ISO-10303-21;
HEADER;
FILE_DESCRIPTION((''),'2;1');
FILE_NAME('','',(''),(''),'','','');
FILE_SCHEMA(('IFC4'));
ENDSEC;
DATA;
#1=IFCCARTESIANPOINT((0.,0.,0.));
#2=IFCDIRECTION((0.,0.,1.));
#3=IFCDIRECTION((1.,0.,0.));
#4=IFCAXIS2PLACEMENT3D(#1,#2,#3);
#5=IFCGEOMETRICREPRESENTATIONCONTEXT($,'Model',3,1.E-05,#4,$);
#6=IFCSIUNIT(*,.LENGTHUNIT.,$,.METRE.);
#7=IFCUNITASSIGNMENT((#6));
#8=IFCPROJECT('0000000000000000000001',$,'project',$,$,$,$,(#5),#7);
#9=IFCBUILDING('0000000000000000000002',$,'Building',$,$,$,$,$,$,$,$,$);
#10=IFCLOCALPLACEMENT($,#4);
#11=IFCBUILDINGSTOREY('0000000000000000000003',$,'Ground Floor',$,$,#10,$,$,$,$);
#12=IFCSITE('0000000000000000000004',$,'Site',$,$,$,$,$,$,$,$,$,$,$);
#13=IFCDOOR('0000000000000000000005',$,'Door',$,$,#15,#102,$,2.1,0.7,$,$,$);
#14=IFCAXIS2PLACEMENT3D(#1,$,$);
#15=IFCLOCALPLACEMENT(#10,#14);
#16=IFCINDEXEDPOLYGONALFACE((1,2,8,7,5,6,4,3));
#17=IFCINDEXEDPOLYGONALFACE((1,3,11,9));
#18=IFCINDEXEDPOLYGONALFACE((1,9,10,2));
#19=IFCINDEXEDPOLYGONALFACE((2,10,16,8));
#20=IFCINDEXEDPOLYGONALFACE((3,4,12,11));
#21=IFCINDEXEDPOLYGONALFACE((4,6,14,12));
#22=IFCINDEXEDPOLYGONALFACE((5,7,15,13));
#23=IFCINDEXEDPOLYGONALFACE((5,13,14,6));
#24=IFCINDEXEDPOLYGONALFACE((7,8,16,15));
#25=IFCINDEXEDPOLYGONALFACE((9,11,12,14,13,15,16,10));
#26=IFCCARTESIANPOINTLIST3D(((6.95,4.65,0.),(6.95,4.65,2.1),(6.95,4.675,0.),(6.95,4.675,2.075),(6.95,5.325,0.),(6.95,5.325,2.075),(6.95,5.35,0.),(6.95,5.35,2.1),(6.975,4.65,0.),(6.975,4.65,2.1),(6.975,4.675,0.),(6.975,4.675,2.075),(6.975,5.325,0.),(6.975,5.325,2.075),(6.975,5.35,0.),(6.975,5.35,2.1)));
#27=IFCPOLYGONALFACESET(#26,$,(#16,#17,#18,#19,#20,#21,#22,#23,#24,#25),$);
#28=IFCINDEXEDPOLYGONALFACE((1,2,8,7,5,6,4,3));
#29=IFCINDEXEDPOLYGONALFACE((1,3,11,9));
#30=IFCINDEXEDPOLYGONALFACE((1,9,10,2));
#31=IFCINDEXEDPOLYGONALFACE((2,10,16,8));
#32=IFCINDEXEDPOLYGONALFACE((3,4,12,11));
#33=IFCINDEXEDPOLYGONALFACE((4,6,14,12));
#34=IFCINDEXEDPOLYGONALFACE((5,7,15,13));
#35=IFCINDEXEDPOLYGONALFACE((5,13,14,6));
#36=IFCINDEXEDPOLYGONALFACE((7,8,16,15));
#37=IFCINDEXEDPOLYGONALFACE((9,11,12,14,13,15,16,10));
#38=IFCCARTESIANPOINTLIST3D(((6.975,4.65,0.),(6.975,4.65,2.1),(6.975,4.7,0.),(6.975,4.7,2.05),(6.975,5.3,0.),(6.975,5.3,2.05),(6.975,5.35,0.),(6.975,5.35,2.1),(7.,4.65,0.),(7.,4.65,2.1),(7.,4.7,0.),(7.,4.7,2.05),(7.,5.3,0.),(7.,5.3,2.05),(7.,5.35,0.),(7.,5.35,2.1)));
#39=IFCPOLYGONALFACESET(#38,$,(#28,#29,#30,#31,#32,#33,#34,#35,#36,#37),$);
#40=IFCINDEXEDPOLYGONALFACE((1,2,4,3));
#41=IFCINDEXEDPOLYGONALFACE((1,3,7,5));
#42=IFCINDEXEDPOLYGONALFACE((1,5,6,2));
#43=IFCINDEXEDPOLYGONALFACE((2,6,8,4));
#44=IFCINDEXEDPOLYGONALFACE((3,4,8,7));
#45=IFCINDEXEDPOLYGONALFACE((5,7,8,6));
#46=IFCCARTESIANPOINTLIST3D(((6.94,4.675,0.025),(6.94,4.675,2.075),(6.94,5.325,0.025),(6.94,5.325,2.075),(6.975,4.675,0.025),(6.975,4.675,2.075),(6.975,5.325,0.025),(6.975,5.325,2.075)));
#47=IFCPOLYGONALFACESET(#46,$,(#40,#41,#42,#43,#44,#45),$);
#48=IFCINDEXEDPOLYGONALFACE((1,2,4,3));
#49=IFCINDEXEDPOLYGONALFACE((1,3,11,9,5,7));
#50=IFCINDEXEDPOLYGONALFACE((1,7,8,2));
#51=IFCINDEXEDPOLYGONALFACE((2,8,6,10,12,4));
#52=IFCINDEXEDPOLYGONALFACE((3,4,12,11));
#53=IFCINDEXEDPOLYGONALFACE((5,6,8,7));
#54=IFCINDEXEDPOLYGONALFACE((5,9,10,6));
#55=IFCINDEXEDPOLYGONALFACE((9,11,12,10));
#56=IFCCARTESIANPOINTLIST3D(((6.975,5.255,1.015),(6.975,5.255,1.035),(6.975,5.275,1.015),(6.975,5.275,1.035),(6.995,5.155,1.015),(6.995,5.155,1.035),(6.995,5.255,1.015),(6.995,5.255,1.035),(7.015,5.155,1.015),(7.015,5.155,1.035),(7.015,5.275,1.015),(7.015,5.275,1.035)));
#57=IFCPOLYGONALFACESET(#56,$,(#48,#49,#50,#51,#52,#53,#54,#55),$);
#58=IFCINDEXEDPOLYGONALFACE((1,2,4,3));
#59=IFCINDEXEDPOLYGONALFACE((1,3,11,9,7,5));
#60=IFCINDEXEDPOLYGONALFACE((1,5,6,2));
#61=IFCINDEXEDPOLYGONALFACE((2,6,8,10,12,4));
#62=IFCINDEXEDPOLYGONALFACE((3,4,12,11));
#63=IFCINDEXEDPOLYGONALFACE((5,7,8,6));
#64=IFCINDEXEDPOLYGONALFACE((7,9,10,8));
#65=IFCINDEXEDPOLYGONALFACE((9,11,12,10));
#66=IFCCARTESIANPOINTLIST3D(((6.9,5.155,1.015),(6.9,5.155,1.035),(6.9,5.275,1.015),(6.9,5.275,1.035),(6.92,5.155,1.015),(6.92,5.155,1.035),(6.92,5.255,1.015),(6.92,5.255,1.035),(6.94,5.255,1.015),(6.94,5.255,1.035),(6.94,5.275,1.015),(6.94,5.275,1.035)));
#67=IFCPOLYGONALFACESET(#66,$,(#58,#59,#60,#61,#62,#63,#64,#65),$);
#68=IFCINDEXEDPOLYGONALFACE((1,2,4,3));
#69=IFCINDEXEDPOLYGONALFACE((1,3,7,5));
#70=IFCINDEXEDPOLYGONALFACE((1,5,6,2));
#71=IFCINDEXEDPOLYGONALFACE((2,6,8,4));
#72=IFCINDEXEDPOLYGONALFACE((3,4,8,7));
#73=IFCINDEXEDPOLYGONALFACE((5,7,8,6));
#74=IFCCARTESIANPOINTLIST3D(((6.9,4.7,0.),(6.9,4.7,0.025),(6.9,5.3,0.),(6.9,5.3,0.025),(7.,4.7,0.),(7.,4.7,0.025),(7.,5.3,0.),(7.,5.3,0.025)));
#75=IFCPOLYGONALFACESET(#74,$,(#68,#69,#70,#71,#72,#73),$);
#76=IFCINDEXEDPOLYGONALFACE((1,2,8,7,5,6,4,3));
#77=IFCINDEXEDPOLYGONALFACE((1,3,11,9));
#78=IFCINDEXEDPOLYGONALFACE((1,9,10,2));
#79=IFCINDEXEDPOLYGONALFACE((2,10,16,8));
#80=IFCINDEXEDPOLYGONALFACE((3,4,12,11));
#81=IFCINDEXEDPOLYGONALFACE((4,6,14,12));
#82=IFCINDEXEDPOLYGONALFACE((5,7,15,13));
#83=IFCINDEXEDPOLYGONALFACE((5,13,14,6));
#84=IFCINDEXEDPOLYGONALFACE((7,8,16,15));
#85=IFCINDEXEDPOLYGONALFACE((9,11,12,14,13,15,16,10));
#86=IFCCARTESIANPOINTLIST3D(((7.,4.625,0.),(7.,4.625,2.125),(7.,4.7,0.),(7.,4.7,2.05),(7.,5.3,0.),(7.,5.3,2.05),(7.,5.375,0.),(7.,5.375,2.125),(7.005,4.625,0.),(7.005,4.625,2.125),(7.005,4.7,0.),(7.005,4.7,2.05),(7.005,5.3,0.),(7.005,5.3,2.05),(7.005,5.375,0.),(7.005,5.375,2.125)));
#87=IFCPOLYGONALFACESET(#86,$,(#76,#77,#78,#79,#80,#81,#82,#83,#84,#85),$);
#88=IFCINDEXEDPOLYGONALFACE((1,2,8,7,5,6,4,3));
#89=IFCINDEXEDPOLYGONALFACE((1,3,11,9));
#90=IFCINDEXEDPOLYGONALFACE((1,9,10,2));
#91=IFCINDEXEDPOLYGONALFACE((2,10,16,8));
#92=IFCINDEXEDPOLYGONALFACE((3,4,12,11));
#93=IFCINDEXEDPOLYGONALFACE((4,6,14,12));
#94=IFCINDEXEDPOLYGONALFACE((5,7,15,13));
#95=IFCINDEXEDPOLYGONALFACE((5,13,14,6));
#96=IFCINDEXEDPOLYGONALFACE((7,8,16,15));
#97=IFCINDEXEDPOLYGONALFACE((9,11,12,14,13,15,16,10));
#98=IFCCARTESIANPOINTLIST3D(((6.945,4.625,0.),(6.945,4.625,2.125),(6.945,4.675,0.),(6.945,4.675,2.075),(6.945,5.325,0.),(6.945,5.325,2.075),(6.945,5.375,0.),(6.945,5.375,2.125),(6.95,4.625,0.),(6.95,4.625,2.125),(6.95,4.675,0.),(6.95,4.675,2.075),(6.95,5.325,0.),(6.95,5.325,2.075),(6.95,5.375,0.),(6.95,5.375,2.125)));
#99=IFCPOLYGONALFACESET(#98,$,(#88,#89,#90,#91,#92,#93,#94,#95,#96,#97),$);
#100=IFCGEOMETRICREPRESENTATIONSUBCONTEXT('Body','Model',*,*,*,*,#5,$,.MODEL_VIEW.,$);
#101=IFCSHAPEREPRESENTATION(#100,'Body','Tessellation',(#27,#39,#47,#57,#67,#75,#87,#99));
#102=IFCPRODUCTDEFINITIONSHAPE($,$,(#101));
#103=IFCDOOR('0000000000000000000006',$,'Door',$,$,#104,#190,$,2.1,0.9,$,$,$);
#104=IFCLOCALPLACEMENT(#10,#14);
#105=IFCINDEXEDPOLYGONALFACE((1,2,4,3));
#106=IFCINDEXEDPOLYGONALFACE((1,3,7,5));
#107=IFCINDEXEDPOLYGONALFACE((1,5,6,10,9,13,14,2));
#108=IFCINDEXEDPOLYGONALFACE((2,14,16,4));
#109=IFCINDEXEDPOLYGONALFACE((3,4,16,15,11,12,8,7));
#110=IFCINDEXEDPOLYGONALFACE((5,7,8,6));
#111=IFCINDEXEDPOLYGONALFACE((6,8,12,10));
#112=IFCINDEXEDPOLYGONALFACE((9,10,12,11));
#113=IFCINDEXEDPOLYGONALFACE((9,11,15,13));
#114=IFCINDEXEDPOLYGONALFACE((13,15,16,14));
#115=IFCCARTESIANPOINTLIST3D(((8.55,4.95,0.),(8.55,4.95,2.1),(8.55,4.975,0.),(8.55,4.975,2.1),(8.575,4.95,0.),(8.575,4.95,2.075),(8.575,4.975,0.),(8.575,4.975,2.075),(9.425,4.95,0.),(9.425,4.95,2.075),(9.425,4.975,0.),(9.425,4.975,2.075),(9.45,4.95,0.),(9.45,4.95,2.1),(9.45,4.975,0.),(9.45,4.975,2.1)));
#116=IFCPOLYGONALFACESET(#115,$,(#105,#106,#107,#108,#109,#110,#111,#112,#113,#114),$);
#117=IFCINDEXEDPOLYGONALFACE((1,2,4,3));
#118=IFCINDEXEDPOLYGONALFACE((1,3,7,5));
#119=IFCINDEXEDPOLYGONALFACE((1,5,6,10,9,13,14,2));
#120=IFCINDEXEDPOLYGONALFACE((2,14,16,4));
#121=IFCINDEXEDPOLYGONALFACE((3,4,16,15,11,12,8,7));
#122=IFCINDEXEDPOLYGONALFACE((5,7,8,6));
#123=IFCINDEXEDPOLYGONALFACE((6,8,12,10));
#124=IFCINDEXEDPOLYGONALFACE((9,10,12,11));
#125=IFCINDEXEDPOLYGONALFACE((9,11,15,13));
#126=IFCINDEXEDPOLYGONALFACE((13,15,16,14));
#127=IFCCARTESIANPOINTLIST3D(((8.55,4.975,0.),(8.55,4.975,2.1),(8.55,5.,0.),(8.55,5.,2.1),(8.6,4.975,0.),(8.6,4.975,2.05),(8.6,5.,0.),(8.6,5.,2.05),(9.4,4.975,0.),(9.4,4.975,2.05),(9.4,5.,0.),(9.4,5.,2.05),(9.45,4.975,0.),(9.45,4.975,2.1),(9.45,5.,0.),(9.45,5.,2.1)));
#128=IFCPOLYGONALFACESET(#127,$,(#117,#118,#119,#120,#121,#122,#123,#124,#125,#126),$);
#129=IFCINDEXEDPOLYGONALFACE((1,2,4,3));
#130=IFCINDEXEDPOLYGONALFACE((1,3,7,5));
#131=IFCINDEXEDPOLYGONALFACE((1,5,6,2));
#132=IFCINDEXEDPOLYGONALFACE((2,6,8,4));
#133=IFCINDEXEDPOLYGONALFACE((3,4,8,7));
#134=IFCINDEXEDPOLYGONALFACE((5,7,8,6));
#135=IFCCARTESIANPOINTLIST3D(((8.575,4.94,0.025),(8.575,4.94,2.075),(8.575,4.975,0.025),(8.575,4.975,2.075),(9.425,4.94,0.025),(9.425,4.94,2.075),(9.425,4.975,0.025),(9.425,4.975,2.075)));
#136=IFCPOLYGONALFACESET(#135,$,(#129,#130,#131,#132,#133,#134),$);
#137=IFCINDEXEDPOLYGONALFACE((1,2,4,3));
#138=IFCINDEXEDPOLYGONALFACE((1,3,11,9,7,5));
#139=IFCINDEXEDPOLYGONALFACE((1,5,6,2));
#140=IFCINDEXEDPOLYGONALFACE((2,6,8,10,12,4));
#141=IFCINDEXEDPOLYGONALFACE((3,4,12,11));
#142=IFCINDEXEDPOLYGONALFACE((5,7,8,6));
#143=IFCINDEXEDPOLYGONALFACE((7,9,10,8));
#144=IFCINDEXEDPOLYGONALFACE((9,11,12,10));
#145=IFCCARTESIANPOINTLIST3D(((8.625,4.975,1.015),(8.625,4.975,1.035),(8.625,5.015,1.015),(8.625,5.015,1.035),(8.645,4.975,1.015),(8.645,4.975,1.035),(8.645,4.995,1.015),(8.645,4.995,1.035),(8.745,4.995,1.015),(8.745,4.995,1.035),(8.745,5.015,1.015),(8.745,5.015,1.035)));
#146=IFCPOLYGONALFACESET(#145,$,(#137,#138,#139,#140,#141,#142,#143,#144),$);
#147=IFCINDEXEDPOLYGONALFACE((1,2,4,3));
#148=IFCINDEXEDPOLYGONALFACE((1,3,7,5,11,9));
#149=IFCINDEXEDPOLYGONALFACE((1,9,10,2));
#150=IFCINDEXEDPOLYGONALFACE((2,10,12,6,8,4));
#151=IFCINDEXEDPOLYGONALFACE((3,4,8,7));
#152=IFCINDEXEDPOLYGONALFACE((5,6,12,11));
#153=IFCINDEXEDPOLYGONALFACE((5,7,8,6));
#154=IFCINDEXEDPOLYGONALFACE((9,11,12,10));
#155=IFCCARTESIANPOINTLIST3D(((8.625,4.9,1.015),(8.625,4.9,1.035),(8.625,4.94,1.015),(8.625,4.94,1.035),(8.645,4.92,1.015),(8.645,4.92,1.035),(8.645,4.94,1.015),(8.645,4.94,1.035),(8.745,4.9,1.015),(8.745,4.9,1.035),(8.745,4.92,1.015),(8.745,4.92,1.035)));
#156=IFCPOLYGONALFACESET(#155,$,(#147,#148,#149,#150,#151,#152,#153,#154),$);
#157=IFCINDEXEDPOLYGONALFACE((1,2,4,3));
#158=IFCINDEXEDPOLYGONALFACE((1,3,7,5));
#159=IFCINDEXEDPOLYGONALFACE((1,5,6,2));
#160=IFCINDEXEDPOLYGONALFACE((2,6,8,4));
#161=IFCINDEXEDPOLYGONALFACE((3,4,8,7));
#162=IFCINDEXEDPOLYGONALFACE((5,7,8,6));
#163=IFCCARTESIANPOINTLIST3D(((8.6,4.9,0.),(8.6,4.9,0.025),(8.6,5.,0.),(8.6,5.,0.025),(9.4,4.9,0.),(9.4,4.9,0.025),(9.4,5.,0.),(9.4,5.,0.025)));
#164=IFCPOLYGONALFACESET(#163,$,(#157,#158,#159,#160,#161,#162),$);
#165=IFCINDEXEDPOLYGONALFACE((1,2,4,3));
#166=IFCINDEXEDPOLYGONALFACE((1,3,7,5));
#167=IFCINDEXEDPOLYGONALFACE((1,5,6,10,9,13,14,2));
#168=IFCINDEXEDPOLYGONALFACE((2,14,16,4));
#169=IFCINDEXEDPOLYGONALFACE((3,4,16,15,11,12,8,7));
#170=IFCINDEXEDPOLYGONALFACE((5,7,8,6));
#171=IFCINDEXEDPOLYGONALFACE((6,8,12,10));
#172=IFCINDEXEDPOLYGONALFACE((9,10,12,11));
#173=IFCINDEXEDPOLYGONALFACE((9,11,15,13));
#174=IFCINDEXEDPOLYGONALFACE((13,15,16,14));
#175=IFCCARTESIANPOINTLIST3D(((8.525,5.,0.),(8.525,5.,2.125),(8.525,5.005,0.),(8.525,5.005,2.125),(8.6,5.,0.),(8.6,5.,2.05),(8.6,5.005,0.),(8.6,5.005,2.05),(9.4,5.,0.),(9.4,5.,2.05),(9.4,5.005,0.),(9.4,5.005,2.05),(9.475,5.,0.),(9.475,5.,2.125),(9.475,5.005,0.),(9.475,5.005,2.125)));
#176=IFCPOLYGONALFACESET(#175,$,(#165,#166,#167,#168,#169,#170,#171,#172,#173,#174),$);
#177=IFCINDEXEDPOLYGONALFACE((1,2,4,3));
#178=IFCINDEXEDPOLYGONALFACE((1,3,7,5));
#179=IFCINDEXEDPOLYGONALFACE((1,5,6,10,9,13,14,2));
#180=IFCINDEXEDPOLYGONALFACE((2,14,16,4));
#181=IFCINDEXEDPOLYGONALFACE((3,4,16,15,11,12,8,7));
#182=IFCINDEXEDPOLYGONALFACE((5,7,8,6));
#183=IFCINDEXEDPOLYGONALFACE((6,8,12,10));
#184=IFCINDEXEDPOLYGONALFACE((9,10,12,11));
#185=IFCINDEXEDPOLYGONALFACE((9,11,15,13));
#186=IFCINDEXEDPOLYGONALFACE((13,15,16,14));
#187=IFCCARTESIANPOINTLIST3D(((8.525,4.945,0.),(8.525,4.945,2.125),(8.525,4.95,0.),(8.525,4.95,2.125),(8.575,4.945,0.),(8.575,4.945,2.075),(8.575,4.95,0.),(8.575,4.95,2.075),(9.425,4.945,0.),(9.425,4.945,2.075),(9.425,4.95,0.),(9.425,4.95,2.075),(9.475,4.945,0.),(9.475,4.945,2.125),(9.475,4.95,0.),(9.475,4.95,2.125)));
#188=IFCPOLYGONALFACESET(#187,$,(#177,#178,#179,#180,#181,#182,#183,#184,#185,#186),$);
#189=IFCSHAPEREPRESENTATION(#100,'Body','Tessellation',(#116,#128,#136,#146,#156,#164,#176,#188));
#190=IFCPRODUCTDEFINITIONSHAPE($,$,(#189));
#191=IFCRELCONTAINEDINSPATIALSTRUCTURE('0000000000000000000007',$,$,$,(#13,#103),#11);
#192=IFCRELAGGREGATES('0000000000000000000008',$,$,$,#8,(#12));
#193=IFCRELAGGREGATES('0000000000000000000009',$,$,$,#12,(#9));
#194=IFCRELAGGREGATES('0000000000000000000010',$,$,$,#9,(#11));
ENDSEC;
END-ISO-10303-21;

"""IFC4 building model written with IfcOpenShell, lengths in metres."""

from ifc_helpers import new_model, si_unit, frame, origin_with_axes, place, context, subcontext, project, spatial, line, indexed_curve, outline, extrude, element, save


model = new_model("IFC4")

# Units and contexts
model_context = context("Model", 3, precision=1e-05, world=origin_with_axes())
body_context = subcontext(model_context, "Body", "Model", "MODEL_VIEW")
ifc_project = project(units=[si_unit("LENGTHUNIT", "METRE")], contexts=[model_context])

# Site, building, storey
site = spatial("IfcSite", under=ifc_project, Name="Site")
building = spatial("IfcBuilding", under=site, Name="Building")
storey_placement = place(None, origin_with_axes())
storey = spatial("IfcBuildingStorey", under=building, at=storey_placement, Name="Ground Floor")

# Doors
door_1_placement = place(storey_placement, frame((7.0, 4.65, 0.0), z_axis=(0.0, 0.0, 1.0), x_axis=(0.0, 1.0, 0.0)))
element("IfcDoor", 1, at=door_1_placement, inside=storey, Name="Door", OverallHeight=2.1, OverallWidth=0.7, context=body_context, shape_type="SweptSolid", body=[
    extrude(outline(indexed_curve([(0.0, 0.0), (0.0, 2.1), (0.7, 2.1), (0.7, 0.0), (0.675, 0.0), (0.675, 2.075), (0.025, 2.075), (0.025, 0.0)], segments=[line(1, 2, 3, 4, 5, 6, 7, 8, 1)])), frame((0.0, 0.025, 0.0), z_axis=(0.0, -1.0, 0.0), x_axis=(1.0, 0.0, 0.0)), (0.0, 0.0, -1.0), 0.025),
    extrude(outline(indexed_curve([(0.0, 0.0), (0.0, 2.1), (0.7, 2.1), (0.7, 0.0), (0.65, 0.0), (0.65, 2.05), (0.05, 2.05), (0.05, 0.0)], segments=[line(1, 2, 3, 4, 5, 6, 7, 8, 1)])), frame((0.0, 0.0, 0.0), z_axis=(0.0, -1.0, 0.0), x_axis=(1.0, 0.0, 0.0)), (0.0, 0.0, -1.0), 0.025),
    extrude(outline(indexed_curve([(0.0, 0.0), (0.65, 0.0), (0.65, 0.035), (0.0, 0.035)], segments=[line(1, 2, 3, 4, 1)])), frame((0.025, 0.025, 0.025), z_axis=(0.0, 0.0, 1.0), x_axis=(1.0, 0.0, 0.0)), (0.0, 0.0, 1.0), 2.05),
    extrude(outline(indexed_curve([(0.0, 0.0), (0.0, -0.04), (-0.12, -0.04), (-0.12, -0.02), (-0.02, -0.02), (-0.02, 0.0)], segments=[line(1, 2, 3, 4, 5, 6, 1)])), frame((0.625, 0.025, 1.015), z_axis=(0.0, 0.0, 1.0), x_axis=(1.0, 0.0, 0.0)), (0.0, 0.0, 1.0), 0.02),
    extrude(outline(indexed_curve([(0.0, 0.0), (0.0, 0.04), (-0.12, 0.04), (-0.12, 0.02), (-0.02, 0.02), (-0.02, 0.0)], segments=[line(1, 2, 3, 4, 5, 6, 1)])), frame((0.625, 0.06, 1.015), z_axis=(0.0, 0.0, 1.0), x_axis=(1.0, 0.0, 0.0)), (0.0, 0.0, 1.0), 0.02),
    extrude(outline(indexed_curve([(0.0, 0.0), (0.6, 0.0), (0.6, 0.1), (0.0, 0.1)], segments=[line(1, 2, 3, 4, 1)])), frame((0.05, 0.0, 0.0), z_axis=(0.0, 0.0, 1.0), x_axis=(1.0, 0.0, 0.0)), (0.0, 0.0, 1.0), 0.025),
    extrude(outline(indexed_curve([(0.0, 0.0), (0.0, 2.125), (0.75, 2.125), (0.75, 0.0), (0.675, 0.0), (0.675, 2.05), (0.075, 2.05), (0.075, 0.0)], segments=[line(1, 2, 3, 4, 5, 6, 7, 8, 1)])), frame((-0.025, -0.005, 0.0), z_axis=(0.0, -1.0, 0.0), x_axis=(1.0, 0.0, 0.0)), (0.0, 0.0, -1.0), 0.005),
    extrude(outline(indexed_curve([(0.0, 0.0), (0.0, 2.125), (0.75, 2.125), (0.75, 0.0), (0.7, 0.0), (0.7, 2.075), (0.05, 2.075), (0.05, 0.0)], segments=[line(1, 2, 3, 4, 5, 6, 7, 8, 1)])), frame((-0.025, 0.05, 0.0), z_axis=(0.0, -1.0, 0.0), x_axis=(1.0, 0.0, 0.0)), (0.0, 0.0, -1.0), 0.005),
])
door_2_placement = place(storey_placement, frame((9.45, 5.0, 0.0), z_axis=(0.0, 0.0, 1.0), x_axis=(-1.0, 0.0, 0.0)))
element("IfcDoor", 2, at=door_2_placement, inside=storey, Name="Door", OverallHeight=2.1, OverallWidth=0.9, context=body_context, shape_type="SweptSolid", body=[
    extrude(outline(indexed_curve([(0.0, 0.0), (0.0, 2.1), (0.9, 2.1), (0.9, 0.0), (0.875, 0.0), (0.875, 2.075), (0.025, 2.075), (0.025, 0.0)], segments=[line(1, 2, 3, 4, 5, 6, 7, 8, 1)])), frame((0.0, 0.025, 0.0), z_axis=(0.0, -1.0, 0.0), x_axis=(1.0, 0.0, 0.0)), (0.0, 0.0, -1.0), 0.025),
    extrude(outline(indexed_curve([(0.0, 0.0), (0.0, 2.1), (0.9, 2.1), (0.9, 0.0), (0.85, 0.0), (0.85, 2.05), (0.05, 2.05), (0.05, 0.0)], segments=[line(1, 2, 3, 4, 5, 6, 7, 8, 1)])), frame((0.0, 0.0, 0.0), z_axis=(0.0, -1.0, 0.0), x_axis=(1.0, 0.0, 0.0)), (0.0, 0.0, -1.0), 0.025),
    extrude(outline(indexed_curve([(0.0, 0.0), (0.85, 0.0), (0.85, 0.035), (0.0, 0.035)], segments=[line(1, 2, 3, 4, 1)])), frame((0.025, 0.025, 0.025), z_axis=(0.0, 0.0, 1.0), x_axis=(1.0, 0.0, 0.0)), (0.0, 0.0, 1.0), 2.05),
    extrude(outline(indexed_curve([(0.0, 0.0), (0.0, -0.04), (-0.12, -0.04), (-0.12, -0.02), (-0.02, -0.02), (-0.02, 0.0)], segments=[line(1, 2, 3, 4, 5, 6, 1)])), frame((0.825, 0.025, 1.015), z_axis=(0.0, 0.0, 1.0), x_axis=(1.0, 0.0, 0.0)), (0.0, 0.0, 1.0), 0.02),
    extrude(outline(indexed_curve([(0.0, 0.0), (0.0, 0.04), (-0.12, 0.04), (-0.12, 0.02), (-0.02, 0.02), (-0.02, 0.0)], segments=[line(1, 2, 3, 4, 5, 6, 1)])), frame((0.825, 0.06, 1.015), z_axis=(0.0, 0.0, 1.0), x_axis=(1.0, 0.0, 0.0)), (0.0, 0.0, 1.0), 0.02),
    extrude(outline(indexed_curve([(0.0, 0.0), (0.8, 0.0), (0.8, 0.1), (0.0, 0.1)], segments=[line(1, 2, 3, 4, 1)])), frame((0.05, 0.0, 0.0), z_axis=(0.0, 0.0, 1.0), x_axis=(1.0, 0.0, 0.0)), (0.0, 0.0, 1.0), 0.025),
    extrude(outline(indexed_curve([(0.0, 0.0), (0.0, 2.125), (0.95, 2.125), (0.95, 0.0), (0.875, 0.0), (0.875, 2.05), (0.075, 2.05), (0.075, 0.0)], segments=[line(1, 2, 3, 4, 5, 6, 7, 8, 1)])), frame((-0.025, -0.005, 0.0), z_axis=(0.0, -1.0, 0.0), x_axis=(1.0, 0.0, 0.0)), (0.0, 0.0, -1.0), 0.005),
    extrude(outline(indexed_curve([(0.0, 0.0), (0.0, 2.125), (0.95, 2.125), (0.95, 0.0), (0.9, 0.0), (0.9, 2.075), (0.05, 2.075), (0.05, 0.0)], segments=[line(1, 2, 3, 4, 5, 6, 7, 8, 1)])), frame((-0.025, 0.05, 0.0), z_axis=(0.0, -1.0, 0.0), x_axis=(1.0, 0.0, 0.0)), (0.0, 0.0, -1.0), 0.005),
])

save(model, "model.ifc")
